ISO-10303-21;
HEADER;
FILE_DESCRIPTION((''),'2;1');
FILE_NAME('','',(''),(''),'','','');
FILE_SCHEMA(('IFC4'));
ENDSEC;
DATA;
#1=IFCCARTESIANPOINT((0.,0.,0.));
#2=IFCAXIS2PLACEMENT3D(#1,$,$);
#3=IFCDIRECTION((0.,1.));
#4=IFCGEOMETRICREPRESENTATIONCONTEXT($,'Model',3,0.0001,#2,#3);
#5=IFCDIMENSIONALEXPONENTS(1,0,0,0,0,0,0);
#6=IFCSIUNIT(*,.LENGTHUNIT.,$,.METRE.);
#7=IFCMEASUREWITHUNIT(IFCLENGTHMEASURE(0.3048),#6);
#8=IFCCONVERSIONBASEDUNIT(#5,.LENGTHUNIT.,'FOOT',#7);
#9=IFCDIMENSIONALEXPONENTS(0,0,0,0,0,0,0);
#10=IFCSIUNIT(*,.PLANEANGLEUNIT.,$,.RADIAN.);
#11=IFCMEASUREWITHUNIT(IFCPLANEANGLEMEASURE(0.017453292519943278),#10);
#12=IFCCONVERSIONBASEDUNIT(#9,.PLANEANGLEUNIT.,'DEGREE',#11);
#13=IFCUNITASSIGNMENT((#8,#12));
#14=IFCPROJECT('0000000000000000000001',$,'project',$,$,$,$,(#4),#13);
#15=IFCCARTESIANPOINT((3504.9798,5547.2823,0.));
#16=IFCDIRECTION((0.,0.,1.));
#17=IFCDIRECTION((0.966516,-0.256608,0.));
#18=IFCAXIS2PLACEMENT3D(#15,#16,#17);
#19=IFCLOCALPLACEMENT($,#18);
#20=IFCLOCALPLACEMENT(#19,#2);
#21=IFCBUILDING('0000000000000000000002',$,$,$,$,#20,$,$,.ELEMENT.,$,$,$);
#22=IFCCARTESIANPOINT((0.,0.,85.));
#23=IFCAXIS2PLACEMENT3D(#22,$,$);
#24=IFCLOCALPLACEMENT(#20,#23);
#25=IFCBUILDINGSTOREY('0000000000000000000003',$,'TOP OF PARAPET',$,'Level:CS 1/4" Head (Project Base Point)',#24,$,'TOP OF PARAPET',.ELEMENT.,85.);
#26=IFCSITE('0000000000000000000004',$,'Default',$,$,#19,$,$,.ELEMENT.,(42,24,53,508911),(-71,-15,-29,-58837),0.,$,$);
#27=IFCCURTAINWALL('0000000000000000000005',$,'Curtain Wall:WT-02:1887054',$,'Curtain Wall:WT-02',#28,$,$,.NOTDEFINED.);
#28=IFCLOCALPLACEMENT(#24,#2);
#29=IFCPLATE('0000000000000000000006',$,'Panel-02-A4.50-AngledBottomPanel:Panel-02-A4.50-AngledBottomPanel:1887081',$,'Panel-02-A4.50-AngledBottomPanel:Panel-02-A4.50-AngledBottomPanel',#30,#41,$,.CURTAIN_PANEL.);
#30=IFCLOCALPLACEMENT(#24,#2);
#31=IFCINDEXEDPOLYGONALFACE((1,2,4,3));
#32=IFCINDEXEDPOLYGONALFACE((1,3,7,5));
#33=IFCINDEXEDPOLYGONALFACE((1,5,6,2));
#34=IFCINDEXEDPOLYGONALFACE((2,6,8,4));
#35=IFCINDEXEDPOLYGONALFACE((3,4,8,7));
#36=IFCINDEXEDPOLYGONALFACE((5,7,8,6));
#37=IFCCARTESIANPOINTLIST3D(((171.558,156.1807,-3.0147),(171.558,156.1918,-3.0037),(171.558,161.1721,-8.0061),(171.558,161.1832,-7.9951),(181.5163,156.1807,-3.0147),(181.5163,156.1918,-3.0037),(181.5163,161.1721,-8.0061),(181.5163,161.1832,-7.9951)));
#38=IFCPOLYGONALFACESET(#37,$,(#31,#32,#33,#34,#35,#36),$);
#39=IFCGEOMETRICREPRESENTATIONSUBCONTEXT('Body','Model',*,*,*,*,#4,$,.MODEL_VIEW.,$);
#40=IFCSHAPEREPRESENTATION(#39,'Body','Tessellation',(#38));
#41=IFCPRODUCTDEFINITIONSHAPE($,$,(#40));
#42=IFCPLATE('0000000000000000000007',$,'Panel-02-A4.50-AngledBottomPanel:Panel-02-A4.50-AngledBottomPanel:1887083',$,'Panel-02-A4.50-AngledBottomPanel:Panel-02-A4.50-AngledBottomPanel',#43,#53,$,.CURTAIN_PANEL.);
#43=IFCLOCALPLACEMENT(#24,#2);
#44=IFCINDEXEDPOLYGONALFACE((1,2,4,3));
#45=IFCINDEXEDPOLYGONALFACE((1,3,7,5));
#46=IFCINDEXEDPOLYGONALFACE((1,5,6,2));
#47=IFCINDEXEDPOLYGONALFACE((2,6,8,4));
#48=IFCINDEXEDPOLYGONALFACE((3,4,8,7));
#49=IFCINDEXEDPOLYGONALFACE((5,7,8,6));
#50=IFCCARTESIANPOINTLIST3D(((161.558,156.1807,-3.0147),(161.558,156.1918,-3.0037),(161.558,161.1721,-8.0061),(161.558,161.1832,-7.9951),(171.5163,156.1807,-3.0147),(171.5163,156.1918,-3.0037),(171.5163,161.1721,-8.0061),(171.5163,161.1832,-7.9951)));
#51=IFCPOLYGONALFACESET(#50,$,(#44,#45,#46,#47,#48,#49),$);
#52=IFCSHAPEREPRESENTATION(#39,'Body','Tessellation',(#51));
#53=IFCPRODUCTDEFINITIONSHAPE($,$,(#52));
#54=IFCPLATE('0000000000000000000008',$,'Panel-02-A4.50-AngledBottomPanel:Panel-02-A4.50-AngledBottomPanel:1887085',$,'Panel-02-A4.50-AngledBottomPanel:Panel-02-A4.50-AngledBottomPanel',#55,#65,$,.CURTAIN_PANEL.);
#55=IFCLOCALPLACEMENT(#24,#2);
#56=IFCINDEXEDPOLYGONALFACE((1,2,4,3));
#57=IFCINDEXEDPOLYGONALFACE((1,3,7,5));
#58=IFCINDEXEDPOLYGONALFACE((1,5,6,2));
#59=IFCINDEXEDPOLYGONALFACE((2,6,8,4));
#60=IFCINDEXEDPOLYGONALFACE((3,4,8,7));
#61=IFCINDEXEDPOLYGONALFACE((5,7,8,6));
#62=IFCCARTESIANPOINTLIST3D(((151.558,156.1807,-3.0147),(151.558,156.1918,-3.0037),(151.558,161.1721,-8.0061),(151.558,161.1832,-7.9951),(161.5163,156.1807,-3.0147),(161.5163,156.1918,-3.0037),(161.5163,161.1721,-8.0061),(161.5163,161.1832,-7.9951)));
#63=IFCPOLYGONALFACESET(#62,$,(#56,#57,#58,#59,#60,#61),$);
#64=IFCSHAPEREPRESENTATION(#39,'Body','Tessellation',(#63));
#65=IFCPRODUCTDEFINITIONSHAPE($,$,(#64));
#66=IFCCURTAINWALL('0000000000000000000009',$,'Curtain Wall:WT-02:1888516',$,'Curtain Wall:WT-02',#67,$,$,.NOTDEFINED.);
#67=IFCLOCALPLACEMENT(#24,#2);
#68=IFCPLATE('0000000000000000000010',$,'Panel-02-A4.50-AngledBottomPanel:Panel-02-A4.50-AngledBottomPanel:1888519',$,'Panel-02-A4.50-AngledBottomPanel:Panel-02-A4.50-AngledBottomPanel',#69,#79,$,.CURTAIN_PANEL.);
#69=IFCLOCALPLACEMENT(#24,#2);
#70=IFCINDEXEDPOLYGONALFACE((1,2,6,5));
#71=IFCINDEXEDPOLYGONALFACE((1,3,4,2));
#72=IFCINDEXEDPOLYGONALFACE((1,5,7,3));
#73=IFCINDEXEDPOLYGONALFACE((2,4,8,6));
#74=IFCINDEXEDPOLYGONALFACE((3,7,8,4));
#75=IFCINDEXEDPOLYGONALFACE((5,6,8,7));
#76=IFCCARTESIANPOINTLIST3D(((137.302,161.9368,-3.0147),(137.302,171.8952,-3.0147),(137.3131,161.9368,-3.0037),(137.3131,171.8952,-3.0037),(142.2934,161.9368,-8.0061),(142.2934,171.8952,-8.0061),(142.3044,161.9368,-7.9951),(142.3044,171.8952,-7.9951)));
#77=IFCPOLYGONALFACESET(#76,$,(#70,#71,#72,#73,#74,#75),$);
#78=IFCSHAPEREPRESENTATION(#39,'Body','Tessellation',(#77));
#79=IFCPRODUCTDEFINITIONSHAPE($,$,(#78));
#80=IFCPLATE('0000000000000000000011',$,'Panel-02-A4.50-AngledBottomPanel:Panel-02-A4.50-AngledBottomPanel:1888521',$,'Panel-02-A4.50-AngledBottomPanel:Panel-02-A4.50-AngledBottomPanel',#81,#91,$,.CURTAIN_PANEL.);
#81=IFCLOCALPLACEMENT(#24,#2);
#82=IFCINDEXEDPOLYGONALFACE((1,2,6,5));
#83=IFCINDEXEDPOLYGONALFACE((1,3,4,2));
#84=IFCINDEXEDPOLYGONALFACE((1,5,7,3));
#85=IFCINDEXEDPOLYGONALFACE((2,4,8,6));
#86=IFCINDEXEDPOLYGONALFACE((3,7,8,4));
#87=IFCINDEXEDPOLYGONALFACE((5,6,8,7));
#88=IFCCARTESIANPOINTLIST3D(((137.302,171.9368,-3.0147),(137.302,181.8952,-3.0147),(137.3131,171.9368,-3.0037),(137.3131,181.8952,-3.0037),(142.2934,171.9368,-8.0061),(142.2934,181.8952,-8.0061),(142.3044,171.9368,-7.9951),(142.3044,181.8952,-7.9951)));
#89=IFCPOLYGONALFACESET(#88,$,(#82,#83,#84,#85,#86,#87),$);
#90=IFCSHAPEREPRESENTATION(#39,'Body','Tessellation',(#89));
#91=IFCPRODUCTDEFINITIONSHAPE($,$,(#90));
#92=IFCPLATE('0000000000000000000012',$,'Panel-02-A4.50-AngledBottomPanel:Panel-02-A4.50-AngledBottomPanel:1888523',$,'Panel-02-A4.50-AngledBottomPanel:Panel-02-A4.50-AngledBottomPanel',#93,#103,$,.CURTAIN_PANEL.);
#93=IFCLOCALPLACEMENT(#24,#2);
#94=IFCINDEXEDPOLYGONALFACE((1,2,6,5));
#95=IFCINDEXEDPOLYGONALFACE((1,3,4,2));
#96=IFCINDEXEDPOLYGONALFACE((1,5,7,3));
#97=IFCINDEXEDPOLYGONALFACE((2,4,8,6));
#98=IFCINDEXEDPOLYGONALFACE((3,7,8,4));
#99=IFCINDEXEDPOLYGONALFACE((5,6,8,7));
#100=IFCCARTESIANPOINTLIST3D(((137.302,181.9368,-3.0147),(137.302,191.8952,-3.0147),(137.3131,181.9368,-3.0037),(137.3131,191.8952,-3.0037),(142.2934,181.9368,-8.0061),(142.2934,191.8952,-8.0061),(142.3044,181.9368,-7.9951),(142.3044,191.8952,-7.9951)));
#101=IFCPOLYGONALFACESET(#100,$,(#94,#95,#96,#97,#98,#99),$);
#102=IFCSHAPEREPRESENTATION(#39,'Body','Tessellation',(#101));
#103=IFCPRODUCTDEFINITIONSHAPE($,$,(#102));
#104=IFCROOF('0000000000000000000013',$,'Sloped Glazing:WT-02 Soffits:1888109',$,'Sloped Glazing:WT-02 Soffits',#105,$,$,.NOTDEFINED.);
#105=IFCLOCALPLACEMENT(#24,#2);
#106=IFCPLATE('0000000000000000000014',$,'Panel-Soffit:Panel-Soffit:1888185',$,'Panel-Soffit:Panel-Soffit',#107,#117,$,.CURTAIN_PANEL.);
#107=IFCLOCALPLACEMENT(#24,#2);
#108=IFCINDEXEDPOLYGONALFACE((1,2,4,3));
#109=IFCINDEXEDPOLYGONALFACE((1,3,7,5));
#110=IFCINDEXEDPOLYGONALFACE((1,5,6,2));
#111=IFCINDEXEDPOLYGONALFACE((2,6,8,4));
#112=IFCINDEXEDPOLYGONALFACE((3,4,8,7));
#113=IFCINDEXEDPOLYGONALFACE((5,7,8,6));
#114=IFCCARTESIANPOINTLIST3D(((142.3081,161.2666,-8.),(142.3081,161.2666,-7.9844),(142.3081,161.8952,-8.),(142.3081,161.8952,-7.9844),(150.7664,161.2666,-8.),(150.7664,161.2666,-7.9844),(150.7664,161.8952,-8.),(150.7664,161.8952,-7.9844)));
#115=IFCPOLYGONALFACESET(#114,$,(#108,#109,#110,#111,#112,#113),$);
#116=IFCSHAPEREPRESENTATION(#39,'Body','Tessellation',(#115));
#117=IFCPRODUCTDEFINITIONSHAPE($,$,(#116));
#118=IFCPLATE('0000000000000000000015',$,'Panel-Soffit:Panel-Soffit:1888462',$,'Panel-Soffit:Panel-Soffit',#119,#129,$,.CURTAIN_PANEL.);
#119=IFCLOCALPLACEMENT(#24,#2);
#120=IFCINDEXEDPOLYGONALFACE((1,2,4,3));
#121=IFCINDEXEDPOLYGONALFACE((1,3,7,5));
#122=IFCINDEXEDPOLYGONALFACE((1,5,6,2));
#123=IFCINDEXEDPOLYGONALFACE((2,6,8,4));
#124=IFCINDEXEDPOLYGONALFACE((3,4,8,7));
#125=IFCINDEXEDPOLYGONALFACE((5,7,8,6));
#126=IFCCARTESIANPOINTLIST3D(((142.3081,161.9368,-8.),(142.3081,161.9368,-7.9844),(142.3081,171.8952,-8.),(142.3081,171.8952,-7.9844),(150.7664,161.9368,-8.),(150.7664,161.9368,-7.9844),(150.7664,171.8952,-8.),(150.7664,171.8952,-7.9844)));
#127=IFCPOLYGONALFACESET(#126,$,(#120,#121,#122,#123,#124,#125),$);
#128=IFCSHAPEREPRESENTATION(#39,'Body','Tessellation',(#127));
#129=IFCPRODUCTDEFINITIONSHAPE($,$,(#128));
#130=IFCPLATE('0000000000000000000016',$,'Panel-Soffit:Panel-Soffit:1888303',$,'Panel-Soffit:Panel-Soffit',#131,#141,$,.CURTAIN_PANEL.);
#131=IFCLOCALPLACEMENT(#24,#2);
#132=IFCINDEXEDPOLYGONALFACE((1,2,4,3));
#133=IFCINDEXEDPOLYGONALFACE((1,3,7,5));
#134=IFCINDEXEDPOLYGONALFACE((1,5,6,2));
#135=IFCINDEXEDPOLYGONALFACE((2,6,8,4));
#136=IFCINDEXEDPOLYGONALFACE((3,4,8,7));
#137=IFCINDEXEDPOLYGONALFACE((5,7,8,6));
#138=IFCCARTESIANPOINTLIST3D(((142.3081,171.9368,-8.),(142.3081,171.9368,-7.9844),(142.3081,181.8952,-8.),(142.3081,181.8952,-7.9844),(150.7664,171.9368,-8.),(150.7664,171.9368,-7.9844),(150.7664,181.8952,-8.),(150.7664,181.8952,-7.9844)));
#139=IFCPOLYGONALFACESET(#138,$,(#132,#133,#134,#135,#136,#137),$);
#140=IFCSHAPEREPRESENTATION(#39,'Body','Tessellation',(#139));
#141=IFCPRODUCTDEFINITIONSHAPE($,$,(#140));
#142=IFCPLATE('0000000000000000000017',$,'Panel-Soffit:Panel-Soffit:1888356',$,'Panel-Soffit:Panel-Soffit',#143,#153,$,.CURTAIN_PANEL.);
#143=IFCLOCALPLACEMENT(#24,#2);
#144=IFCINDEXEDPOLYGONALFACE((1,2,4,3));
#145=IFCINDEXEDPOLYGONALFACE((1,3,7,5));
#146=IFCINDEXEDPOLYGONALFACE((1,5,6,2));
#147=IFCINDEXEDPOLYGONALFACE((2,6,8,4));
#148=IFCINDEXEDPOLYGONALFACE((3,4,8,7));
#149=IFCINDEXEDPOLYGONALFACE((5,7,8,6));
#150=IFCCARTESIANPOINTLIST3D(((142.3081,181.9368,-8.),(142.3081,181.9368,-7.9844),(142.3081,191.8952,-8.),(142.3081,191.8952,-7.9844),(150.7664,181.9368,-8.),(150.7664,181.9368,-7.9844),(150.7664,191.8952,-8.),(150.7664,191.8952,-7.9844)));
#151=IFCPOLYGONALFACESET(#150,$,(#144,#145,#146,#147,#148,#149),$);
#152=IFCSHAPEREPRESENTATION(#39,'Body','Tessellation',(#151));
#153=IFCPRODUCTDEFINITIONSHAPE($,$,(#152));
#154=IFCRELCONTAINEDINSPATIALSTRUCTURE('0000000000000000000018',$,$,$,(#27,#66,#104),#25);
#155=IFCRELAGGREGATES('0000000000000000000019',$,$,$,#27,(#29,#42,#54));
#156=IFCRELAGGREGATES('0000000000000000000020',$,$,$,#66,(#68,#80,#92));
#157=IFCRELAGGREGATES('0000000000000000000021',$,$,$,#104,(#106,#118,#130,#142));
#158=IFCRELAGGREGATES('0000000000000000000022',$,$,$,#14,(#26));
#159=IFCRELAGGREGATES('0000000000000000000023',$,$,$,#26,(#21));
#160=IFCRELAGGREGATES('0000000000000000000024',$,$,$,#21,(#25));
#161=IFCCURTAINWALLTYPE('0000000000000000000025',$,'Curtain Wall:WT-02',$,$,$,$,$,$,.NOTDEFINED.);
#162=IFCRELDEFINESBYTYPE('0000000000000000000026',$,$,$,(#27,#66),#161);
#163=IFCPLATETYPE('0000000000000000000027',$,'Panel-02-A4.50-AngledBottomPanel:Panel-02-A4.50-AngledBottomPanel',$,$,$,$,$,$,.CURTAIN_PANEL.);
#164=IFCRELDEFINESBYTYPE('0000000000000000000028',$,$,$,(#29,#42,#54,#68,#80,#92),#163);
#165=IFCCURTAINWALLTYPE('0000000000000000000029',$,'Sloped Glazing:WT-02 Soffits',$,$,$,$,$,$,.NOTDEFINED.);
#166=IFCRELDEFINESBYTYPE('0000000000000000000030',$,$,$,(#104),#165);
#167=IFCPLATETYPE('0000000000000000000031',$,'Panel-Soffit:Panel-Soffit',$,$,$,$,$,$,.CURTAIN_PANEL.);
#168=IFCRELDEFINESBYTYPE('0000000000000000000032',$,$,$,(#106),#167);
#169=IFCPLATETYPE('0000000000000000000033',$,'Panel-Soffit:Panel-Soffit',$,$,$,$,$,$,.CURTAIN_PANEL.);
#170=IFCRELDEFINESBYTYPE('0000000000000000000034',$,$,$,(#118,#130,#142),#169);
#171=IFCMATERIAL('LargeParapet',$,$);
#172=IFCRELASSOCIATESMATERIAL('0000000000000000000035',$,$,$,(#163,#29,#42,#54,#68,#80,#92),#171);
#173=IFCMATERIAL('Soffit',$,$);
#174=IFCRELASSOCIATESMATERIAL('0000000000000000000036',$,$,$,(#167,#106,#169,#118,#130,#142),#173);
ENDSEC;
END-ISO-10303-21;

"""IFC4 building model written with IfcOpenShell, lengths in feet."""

from ifc_helpers import new_model, entity, si_unit, converted_unit, direction, frame, origin, place, context, subcontext, project, spatial, indexed_curve, outline, extrude, source, transform, mapped, material, type_object, type_shapes, element, aggregate, save


model = new_model("IFC4")

# Units and contexts
model_context = context("Model", 3, precision=0.0001, world=origin(), true_north=direction((0.0, 1.0)))
body_context = subcontext(model_context, "Body", "Model", "MODEL_VIEW")
ifc_project = project(units=[converted_unit("LENGTHUNIT", "FOOT", entity("IfcLengthMeasure", 0.3048), si_unit("LENGTHUNIT", "METRE"), dimensions=[1, 0, 0, 0, 0, 0, 0]), converted_unit("PLANEANGLEUNIT", "DEGREE", entity("IfcPlaneAngleMeasure", 0.017453292519943278), si_unit("PLANEANGLEUNIT", "RADIAN"), dimensions=[0, 0, 0, 0, 0, 0, 0])], contexts=[model_context])

# Site, building, storey
site_placement = place(None, frame((3504.9798, 5547.2823, 0.0), z_axis=(0.0, 0.0, 1.0), x_axis=(0.966516, -0.256608, 0.0)))
site = spatial("IfcSite", under=ifc_project, at=site_placement, Name="Default", CompositionType="ELEMENT", RefLatitude=(42, 24, 53, 508911), RefLongitude=(-71, -15, -29, -58837), RefElevation=0.0)
building_placement = place(site_placement, origin())
building = spatial("IfcBuilding", under=site, at=building_placement, CompositionType="ELEMENT")
storey_placement = place(building_placement, frame((0.0, 0.0, 85.0)))
storey = spatial("IfcBuildingStorey", under=building, at=storey_placement, Name="TOP OF PARAPET", ObjectType="Level:CS 1/4\" Head (Project Base Point)", LongName="TOP OF PARAPET", CompositionType="ELEMENT", Elevation=85.0)

# Shared definitions
curtain_wall_type_1 = type_object("IfcCurtainWallType", Name="Curtain Wall:WT-02", PredefinedType="NOTDEFINED")
ifc_material_1 = material(Name="LargeParapet")

# Shared definitions
curtain_wall_type_2 = type_object("IfcCurtainWallType", Name="Sloped Glazing:WT-02 Soffits", PredefinedType="NOTDEFINED")
ifc_material_2 = material(Name="Soffit")

# Curtain walls, plates
curtain_wall_1_placement = place(storey_placement, frame((0.0, 0.0, -85.0)))
curtain_wall_1 = element("IfcCurtainWall", 1, at=curtain_wall_1_placement, inside=storey, type_object=curtain_wall_type_1, Name="Curtain Wall:WT-02:1887054", ObjectType="Curtain Wall:WT-02", PredefinedType="NOTDEFINED")
plate_type_1 = type_object("IfcPlateType", Name="Panel-02-A4.50-AngledBottomPanel:Panel-02-A4.50-AngledBottomPanel", PredefinedType="CURTAIN_PANEL", material=ifc_material_1)
shared_shape_1 = source(origin(), body_context, "Body", "SweptSolid", [
    extrude(outline(indexed_curve([(-0.0078, -4.9792), (0.0078, -4.9792), (0.0078, 4.9792), (-0.0078, 4.9792), (-0.0078, -4.9792)], self_intersect=False)), frame((4.9792, 0.0078, 0.0), z_axis=(0.0, 0.0, 1.0), x_axis=(0.0, -1.0, 0.0)), (0.0, 0.0, 1.0), 7.0589),
])
type_shapes(plate_type_1, [shared_shape_1])
plate_1_placement = place(curtain_wall_1_placement, frame((181.5163, 161.1832, 77.0049), z_axis=(0.0, -0.707107, 0.707107), x_axis=(-1.0, 0.0, 0.0)))
plate_1 = element("IfcPlate", 2, at=plate_1_placement, type_object=plate_type_1, material=ifc_material_1, Name="Panel-02-A4.50-AngledBottomPanel:Panel-02-A4.50-AngledBottomPanel:1887081", ObjectType="Panel-02-A4.50-AngledBottomPanel:Panel-02-A4.50-AngledBottomPanel", PredefinedType="CURTAIN_PANEL", context=body_context, shape_type="MappedRepresentation", body=[
    mapped(shared_shape_1, transform((0.0, 0.0, 0.0), scale=1.0)),
])
plate_2_placement = place(curtain_wall_1_placement, frame((171.5163, 161.1832, 77.0049), z_axis=(0.0, -0.707107, 0.707107), x_axis=(-1.0, 0.0, 0.0)))
plate_2 = element("IfcPlate", 3, at=plate_2_placement, type_object=plate_type_1, material=ifc_material_1, Name="Panel-02-A4.50-AngledBottomPanel:Panel-02-A4.50-AngledBottomPanel:1887083", ObjectType="Panel-02-A4.50-AngledBottomPanel:Panel-02-A4.50-AngledBottomPanel", PredefinedType="CURTAIN_PANEL", context=body_context, shape_type="MappedRepresentation", body=[
    mapped(shared_shape_1, transform((0.0, 0.0, 0.0), scale=1.0)),
])
plate_3_placement = place(curtain_wall_1_placement, frame((161.5163, 161.1832, 77.0049), z_axis=(0.0, -0.707107, 0.707107), x_axis=(-1.0, 0.0, 0.0)))
plate_3 = element("IfcPlate", 4, at=plate_3_placement, type_object=plate_type_1, material=ifc_material_1, Name="Panel-02-A4.50-AngledBottomPanel:Panel-02-A4.50-AngledBottomPanel:1887085", ObjectType="Panel-02-A4.50-AngledBottomPanel:Panel-02-A4.50-AngledBottomPanel", PredefinedType="CURTAIN_PANEL", context=body_context, shape_type="MappedRepresentation", body=[
    mapped(shared_shape_1, transform((0.0, 0.0, 0.0), scale=1.0)),
])
aggregate(curtain_wall_1, [plate_1, plate_2, plate_3])
curtain_wall_2_placement = place(storey_placement, frame((0.0, 0.0, -85.0)))
curtain_wall_2 = element("IfcCurtainWall", 5, at=curtain_wall_2_placement, inside=storey, type_object=curtain_wall_type_1, Name="Curtain Wall:WT-02:1888516", ObjectType="Curtain Wall:WT-02", PredefinedType="NOTDEFINED")
plate_4_placement = place(curtain_wall_2_placement, frame((142.3044, 161.9368, 77.0049), z_axis=(-0.707107, 0.0, 0.707107), x_axis=(0.0, 1.0, 0.0)))
plate_4 = element("IfcPlate", 6, at=plate_4_placement, type_object=plate_type_1, material=ifc_material_1, Name="Panel-02-A4.50-AngledBottomPanel:Panel-02-A4.50-AngledBottomPanel:1888519", ObjectType="Panel-02-A4.50-AngledBottomPanel:Panel-02-A4.50-AngledBottomPanel", PredefinedType="CURTAIN_PANEL", context=body_context, shape_type="MappedRepresentation", body=[
    mapped(shared_shape_1, transform((0.0, 0.0, 0.0), scale=1.0)),
])
plate_5_placement = place(curtain_wall_2_placement, frame((142.3044, 171.9368, 77.0049), z_axis=(-0.707107, 0.0, 0.707107), x_axis=(0.0, 1.0, 0.0)))
plate_5 = element("IfcPlate", 7, at=plate_5_placement, type_object=plate_type_1, material=ifc_material_1, Name="Panel-02-A4.50-AngledBottomPanel:Panel-02-A4.50-AngledBottomPanel:1888521", ObjectType="Panel-02-A4.50-AngledBottomPanel:Panel-02-A4.50-AngledBottomPanel", PredefinedType="CURTAIN_PANEL", context=body_context, shape_type="MappedRepresentation", body=[
    mapped(shared_shape_1, transform((0.0, 0.0, 0.0), scale=1.0)),
])
plate_6_placement = place(curtain_wall_2_placement, frame((142.3044, 181.9368, 77.0049), z_axis=(-0.707107, 0.0, 0.707107), x_axis=(0.0, 1.0, 0.0)))
plate_6 = element("IfcPlate", 8, at=plate_6_placement, type_object=plate_type_1, material=ifc_material_1, Name="Panel-02-A4.50-AngledBottomPanel:Panel-02-A4.50-AngledBottomPanel:1888523", ObjectType="Panel-02-A4.50-AngledBottomPanel:Panel-02-A4.50-AngledBottomPanel", PredefinedType="CURTAIN_PANEL", context=body_context, shape_type="MappedRepresentation", body=[
    mapped(shared_shape_1, transform((0.0, 0.0, 0.0), scale=1.0)),
])
aggregate(curtain_wall_2, [plate_4, plate_5, plate_6])

# Roof, plates
roof_1_placement = place(storey_placement, frame((0.0, 0.0, -85.0)))
roof_1 = element("IfcRoof", 9, at=roof_1_placement, inside=storey, type_object=curtain_wall_type_2, Name="Sloped Glazing:WT-02 Soffits:1888109", ObjectType="Sloped Glazing:WT-02 Soffits", PredefinedType="NOTDEFINED")
plate_type_2 = type_object("IfcPlateType", Name="Panel-Soffit:Panel-Soffit", PredefinedType="CURTAIN_PANEL", material=ifc_material_2)
shared_shape_2 = source(origin(), body_context, "Body", "SweptSolid", [
    extrude(outline(indexed_curve([(-0.0078, -4.2292), (0.0078, -4.2292), (0.0078, 4.2292), (-0.0078, 4.2292), (-0.0078, -4.2292)], self_intersect=False)), frame((4.2292, 0.0078, 0.0), z_axis=(0.0, 0.0, 1.0), x_axis=(0.0, -1.0, 0.0)), (0.0, 0.0, 1.0), 0.6286),
])
type_shapes(plate_type_2, [shared_shape_2])
plate_7_placement = place(roof_1_placement, frame((142.3081, 161.2666, 77.0156), z_axis=(0.0, 1.0, 0.0), x_axis=(1.0, 0.0, 0.0)))
plate_7 = element("IfcPlate", 10, at=plate_7_placement, type_object=plate_type_2, material=ifc_material_2, Name="Panel-Soffit:Panel-Soffit:1888185", ObjectType="Panel-Soffit:Panel-Soffit", PredefinedType="CURTAIN_PANEL", context=body_context, shape_type="MappedRepresentation", body=[
    mapped(shared_shape_2, transform((0.0, 0.0, 0.0), scale=1.0)),
])
plate_type_3 = type_object("IfcPlateType", Name="Panel-Soffit:Panel-Soffit", PredefinedType="CURTAIN_PANEL", material=ifc_material_2)
shared_shape_3 = source(origin(), body_context, "Body", "SweptSolid", [
    extrude(outline(indexed_curve([(-0.0078, -4.2292), (0.0078, -4.2292), (0.0078, 4.2292), (-0.0078, 4.2292), (-0.0078, -4.2292)], self_intersect=False)), frame((4.2292, 0.0078, 0.0), z_axis=(0.0, 0.0, 1.0), x_axis=(0.0, -1.0, 0.0)), (0.0, 0.0, 1.0), 9.9583),
])
type_shapes(plate_type_3, [shared_shape_3])
plate_8_placement = place(roof_1_placement, frame((142.3081, 161.9368, 77.0156), z_axis=(0.0, 1.0, 0.0), x_axis=(1.0, 0.0, 0.0)))
plate_8 = element("IfcPlate", 11, at=plate_8_placement, type_object=plate_type_3, material=ifc_material_2, Name="Panel-Soffit:Panel-Soffit:1888462", ObjectType="Panel-Soffit:Panel-Soffit", PredefinedType="CURTAIN_PANEL", context=body_context, shape_type="MappedRepresentation", body=[
    mapped(shared_shape_3, transform((0.0, 0.0, 0.0), scale=1.0)),
])
plate_9_placement = place(roof_1_placement, frame((142.3081, 171.9368, 77.0156), z_axis=(0.0, 1.0, 0.0), x_axis=(1.0, 0.0, 0.0)))
plate_9 = element("IfcPlate", 12, at=plate_9_placement, type_object=plate_type_3, material=ifc_material_2, Name="Panel-Soffit:Panel-Soffit:1888303", ObjectType="Panel-Soffit:Panel-Soffit", PredefinedType="CURTAIN_PANEL", context=body_context, shape_type="MappedRepresentation", body=[
    mapped(shared_shape_3, transform((0.0, 0.0, 0.0), scale=1.0)),
])
plate_10_placement = place(roof_1_placement, frame((142.3081, 181.9368, 77.0156), z_axis=(0.0, 1.0, 0.0), x_axis=(1.0, 0.0, 0.0)))
plate_10 = element("IfcPlate", 13, at=plate_10_placement, type_object=plate_type_3, material=ifc_material_2, Name="Panel-Soffit:Panel-Soffit:1888356", ObjectType="Panel-Soffit:Panel-Soffit", PredefinedType="CURTAIN_PANEL", context=body_context, shape_type="MappedRepresentation", body=[
    mapped(shared_shape_3, transform((0.0, 0.0, 0.0), scale=1.0)),
])
aggregate(roof_1, [plate_7, plate_8, plate_9, plate_10])

save(model, "model.ifc")
